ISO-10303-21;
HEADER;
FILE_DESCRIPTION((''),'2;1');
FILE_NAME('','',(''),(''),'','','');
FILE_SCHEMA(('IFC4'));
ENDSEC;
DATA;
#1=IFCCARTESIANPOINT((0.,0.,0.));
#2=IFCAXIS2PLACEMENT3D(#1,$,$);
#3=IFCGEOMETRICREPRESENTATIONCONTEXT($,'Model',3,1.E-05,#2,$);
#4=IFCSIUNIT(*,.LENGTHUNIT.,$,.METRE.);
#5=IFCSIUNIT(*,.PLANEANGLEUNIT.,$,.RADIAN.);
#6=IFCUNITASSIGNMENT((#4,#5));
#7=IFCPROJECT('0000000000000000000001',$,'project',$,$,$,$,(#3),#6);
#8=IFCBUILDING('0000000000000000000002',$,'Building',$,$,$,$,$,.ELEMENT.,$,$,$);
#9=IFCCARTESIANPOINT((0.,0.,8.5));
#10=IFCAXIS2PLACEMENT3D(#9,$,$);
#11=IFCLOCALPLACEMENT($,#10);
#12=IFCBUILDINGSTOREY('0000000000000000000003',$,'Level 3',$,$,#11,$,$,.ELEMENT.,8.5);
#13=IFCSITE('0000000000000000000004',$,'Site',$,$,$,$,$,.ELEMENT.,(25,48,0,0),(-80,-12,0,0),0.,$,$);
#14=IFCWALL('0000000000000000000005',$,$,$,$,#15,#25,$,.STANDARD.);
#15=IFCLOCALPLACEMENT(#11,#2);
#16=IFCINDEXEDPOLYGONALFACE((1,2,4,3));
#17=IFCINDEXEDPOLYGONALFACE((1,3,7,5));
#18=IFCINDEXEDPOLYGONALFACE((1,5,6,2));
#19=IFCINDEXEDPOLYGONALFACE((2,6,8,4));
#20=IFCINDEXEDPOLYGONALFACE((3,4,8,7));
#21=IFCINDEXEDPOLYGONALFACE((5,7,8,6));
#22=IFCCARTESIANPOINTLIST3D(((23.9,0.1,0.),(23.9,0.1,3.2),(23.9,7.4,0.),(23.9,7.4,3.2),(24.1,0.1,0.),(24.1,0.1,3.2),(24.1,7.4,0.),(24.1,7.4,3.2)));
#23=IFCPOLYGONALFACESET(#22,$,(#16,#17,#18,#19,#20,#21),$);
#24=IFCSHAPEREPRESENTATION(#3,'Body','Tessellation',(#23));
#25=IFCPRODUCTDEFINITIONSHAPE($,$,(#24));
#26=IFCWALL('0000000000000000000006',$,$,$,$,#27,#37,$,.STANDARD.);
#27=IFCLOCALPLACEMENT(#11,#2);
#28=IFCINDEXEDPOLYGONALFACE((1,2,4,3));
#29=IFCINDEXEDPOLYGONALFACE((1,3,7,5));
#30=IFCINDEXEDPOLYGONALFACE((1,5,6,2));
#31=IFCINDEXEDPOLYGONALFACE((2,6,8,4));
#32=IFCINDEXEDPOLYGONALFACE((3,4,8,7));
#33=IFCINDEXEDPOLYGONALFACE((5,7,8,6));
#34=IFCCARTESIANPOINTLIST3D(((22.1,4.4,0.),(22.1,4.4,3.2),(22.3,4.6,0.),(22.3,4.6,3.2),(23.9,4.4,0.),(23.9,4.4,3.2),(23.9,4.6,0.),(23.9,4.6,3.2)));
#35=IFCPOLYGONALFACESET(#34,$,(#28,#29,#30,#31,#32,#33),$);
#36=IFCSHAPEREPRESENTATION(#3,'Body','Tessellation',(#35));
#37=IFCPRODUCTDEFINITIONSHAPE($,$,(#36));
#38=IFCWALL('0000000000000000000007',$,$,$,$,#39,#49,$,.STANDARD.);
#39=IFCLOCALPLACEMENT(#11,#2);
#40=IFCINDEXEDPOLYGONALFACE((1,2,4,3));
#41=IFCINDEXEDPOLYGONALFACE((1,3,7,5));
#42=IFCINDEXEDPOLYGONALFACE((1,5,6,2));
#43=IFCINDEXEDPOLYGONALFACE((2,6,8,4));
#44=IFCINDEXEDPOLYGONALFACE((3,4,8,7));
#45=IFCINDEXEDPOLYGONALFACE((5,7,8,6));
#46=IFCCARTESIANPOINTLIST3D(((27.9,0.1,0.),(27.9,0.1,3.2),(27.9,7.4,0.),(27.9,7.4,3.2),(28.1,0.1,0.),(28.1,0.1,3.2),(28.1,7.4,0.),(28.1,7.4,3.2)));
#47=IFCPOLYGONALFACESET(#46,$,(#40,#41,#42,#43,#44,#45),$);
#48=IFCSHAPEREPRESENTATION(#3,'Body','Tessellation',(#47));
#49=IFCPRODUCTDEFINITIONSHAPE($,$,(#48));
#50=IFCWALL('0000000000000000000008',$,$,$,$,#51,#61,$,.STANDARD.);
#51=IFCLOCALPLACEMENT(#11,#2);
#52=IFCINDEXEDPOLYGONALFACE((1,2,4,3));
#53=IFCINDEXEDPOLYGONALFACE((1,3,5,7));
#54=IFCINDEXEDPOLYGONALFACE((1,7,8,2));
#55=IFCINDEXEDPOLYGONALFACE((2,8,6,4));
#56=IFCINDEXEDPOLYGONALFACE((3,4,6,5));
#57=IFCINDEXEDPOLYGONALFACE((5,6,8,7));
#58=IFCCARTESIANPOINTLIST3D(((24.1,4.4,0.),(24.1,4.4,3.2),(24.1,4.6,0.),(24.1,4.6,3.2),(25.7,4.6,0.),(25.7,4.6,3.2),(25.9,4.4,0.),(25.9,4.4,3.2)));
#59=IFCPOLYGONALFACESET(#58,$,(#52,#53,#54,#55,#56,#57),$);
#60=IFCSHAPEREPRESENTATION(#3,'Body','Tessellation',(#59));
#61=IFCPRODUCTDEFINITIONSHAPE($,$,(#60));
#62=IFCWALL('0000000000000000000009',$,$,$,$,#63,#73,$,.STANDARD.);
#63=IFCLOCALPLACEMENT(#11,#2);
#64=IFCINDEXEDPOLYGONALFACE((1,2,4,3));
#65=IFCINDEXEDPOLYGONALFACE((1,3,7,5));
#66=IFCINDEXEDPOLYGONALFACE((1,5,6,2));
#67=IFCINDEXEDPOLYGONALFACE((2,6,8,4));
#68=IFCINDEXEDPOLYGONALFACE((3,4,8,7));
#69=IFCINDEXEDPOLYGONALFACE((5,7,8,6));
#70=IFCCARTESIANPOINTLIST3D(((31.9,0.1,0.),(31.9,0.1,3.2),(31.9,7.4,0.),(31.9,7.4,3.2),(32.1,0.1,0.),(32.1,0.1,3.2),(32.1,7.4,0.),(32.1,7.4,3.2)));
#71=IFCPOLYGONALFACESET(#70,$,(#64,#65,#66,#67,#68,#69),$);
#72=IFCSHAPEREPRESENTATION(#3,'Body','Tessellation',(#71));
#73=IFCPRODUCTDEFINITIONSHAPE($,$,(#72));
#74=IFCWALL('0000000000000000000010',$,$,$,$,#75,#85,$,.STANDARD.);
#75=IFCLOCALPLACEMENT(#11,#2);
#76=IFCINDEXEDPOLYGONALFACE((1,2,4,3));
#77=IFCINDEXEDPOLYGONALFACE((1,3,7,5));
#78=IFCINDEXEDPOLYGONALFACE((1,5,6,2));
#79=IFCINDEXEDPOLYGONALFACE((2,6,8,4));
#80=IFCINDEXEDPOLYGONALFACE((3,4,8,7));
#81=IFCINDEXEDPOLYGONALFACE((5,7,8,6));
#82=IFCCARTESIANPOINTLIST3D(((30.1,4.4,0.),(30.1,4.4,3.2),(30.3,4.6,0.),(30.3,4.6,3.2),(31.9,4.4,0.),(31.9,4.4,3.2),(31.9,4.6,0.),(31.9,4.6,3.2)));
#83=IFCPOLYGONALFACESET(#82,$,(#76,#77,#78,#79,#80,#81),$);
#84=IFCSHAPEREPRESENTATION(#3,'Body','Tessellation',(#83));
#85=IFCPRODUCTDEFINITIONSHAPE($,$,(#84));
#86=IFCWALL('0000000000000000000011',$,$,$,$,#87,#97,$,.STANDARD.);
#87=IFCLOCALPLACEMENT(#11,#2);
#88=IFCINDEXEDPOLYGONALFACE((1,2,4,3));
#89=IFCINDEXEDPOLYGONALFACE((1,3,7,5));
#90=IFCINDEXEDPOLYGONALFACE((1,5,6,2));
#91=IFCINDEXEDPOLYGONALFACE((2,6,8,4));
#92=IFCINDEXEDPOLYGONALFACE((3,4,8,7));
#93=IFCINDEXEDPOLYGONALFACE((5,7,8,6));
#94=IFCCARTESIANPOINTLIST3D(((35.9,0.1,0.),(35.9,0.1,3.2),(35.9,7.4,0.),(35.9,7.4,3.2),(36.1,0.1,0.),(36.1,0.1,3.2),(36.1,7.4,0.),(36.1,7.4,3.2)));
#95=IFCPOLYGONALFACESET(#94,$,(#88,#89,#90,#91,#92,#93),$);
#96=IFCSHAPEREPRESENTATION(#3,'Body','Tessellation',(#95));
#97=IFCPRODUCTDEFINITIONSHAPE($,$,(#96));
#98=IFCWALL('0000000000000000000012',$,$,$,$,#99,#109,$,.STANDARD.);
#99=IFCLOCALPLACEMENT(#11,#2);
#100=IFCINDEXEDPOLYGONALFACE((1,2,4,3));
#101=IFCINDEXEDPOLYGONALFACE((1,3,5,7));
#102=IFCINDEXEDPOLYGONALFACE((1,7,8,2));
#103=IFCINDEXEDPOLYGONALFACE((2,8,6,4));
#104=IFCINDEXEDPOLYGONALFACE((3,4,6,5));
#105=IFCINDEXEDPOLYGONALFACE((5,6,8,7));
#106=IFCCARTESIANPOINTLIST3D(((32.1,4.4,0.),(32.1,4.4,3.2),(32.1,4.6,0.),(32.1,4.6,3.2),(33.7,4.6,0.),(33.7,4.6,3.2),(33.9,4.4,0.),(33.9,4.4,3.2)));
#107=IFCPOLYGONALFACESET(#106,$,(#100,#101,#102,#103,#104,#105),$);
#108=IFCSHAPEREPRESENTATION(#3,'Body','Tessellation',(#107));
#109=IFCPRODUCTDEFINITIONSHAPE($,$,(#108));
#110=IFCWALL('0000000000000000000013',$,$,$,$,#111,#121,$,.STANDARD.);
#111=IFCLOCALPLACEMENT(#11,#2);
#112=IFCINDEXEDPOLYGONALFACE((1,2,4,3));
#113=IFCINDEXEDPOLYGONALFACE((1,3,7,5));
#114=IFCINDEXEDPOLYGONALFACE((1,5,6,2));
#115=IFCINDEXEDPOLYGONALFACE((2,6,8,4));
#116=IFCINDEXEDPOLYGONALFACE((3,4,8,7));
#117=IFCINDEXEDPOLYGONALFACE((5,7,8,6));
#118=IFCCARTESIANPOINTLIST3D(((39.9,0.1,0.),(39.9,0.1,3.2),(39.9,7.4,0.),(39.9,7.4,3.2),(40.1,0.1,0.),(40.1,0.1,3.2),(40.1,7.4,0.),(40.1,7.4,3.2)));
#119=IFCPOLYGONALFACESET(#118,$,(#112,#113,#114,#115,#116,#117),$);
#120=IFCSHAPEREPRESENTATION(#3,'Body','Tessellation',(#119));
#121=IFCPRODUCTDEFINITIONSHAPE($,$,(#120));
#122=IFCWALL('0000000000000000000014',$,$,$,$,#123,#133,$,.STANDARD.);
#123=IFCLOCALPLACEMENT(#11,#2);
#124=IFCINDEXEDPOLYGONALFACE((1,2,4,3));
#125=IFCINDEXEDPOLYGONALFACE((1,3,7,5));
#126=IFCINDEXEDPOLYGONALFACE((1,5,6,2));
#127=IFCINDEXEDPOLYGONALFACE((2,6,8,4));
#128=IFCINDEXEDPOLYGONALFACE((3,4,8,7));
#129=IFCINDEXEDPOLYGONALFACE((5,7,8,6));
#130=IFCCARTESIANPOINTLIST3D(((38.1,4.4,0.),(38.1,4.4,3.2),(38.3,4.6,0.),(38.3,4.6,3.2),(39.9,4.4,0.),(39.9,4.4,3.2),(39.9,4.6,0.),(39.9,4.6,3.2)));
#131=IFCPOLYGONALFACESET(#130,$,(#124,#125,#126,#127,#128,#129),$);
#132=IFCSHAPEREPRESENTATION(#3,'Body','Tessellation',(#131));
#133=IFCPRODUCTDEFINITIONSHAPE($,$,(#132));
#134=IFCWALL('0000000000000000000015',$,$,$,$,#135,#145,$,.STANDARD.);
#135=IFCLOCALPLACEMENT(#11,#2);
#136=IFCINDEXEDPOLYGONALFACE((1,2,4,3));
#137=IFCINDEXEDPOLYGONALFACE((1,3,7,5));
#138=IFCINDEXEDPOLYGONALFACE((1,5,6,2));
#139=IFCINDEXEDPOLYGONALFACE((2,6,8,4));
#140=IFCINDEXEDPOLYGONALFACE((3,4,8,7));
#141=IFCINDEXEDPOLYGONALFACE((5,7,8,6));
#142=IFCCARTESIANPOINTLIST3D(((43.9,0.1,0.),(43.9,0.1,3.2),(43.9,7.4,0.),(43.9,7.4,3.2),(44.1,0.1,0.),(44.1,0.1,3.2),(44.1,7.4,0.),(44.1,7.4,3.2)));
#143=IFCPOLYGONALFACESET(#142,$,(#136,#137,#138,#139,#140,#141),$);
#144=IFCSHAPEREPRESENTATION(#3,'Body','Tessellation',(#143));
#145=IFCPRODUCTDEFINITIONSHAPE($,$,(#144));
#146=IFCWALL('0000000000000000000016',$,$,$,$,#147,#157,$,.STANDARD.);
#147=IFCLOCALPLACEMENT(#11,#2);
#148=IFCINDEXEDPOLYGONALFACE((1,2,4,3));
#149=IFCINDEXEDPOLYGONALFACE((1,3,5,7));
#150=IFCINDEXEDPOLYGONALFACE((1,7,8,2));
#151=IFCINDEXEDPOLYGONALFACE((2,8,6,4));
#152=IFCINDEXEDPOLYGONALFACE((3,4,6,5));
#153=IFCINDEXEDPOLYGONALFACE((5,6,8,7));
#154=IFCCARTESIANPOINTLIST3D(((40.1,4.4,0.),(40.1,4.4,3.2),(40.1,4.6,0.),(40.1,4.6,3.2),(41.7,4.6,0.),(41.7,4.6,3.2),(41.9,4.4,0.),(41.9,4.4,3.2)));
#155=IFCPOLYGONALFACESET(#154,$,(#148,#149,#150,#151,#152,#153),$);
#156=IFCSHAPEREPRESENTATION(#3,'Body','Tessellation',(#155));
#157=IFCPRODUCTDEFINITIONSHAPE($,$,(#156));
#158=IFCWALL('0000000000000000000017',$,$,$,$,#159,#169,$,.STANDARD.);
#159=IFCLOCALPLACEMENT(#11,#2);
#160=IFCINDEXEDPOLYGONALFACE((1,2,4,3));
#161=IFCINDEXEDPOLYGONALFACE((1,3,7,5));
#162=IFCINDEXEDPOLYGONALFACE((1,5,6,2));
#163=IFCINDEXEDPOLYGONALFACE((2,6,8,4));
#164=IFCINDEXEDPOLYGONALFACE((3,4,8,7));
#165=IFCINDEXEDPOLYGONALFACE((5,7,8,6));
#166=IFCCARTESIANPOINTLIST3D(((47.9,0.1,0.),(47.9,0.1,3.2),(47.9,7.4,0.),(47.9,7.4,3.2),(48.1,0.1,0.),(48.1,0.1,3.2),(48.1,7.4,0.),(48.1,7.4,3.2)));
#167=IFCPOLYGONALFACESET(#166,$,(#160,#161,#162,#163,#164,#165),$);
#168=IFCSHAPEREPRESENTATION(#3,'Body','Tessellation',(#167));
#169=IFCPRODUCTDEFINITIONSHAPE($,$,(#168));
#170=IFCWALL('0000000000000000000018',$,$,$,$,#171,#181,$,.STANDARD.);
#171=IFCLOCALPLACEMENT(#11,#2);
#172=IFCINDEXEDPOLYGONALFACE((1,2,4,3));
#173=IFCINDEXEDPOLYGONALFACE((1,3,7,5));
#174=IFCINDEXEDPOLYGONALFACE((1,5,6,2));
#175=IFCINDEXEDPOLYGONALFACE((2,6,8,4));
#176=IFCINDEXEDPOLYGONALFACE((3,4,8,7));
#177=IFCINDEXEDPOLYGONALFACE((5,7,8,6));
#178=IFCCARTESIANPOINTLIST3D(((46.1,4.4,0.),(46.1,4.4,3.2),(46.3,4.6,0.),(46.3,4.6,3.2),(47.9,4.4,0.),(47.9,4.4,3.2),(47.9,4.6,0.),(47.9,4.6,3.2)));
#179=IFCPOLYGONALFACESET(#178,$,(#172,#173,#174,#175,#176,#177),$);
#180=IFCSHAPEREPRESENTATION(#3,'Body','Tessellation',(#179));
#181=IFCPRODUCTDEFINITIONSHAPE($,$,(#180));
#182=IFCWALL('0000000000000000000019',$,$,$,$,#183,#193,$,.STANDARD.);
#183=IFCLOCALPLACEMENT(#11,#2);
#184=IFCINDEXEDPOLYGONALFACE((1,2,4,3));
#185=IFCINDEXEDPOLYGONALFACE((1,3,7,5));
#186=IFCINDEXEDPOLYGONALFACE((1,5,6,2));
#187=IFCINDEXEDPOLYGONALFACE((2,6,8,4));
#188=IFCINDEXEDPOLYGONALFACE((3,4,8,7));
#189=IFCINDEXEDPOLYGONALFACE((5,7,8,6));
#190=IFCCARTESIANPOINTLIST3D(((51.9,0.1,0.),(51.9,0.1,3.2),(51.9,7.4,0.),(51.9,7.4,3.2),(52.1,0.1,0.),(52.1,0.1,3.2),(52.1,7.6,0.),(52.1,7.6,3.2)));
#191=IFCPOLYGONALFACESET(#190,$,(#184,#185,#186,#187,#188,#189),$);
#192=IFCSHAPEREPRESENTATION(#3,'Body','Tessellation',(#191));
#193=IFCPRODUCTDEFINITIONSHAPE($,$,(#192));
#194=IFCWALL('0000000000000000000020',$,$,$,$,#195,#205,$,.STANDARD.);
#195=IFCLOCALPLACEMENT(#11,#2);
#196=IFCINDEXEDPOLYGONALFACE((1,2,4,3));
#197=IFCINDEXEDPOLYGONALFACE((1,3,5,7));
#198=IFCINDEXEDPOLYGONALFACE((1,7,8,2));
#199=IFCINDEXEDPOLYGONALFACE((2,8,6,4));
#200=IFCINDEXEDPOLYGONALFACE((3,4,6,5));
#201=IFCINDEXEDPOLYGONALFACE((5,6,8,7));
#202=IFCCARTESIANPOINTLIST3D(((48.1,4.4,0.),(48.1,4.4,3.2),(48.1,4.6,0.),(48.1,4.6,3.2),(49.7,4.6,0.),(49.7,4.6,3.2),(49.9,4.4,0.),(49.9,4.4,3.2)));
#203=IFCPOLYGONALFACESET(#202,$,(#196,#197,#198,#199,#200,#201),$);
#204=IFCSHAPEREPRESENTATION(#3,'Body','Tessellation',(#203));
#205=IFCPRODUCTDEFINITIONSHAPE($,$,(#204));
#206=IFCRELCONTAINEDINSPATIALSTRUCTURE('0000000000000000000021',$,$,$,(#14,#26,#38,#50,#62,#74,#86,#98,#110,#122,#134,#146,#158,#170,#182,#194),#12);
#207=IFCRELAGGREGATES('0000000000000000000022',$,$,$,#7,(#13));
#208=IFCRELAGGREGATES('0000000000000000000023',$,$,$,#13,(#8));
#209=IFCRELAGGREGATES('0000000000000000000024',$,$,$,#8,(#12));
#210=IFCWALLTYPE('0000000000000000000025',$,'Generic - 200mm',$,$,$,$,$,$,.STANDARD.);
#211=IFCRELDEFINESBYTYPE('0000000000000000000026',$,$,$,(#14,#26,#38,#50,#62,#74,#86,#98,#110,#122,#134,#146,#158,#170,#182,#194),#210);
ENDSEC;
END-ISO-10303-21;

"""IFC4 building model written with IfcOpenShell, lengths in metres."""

from ifc_helpers import new_model, si_unit, frame, origin, place, context, project, spatial, polyline, outline, extrude, type_object, element, save


model = new_model("IFC4")

# Units and contexts
model_context = context("Model", 3, precision=1e-05, world=origin())
ifc_project = project(units=[si_unit("LENGTHUNIT", "METRE"), si_unit("PLANEANGLEUNIT", "RADIAN")], contexts=[model_context])

# Site, building, storey
site = spatial("IfcSite", under=ifc_project, Name="Site", CompositionType="ELEMENT", RefLatitude=(25, 48, 0, 0), RefLongitude=(-80, -12, 0, 0), RefElevation=0.0)
building = spatial("IfcBuilding", under=site, Name="Building", CompositionType="ELEMENT")
storey_placement = place(None, frame((0.0, 0.0, 8.5)))
storey = spatial("IfcBuildingStorey", under=building, at=storey_placement, Name="Level 3", CompositionType="ELEMENT", Elevation=8.5)

# Shared definitions
wall_type = type_object("IfcWallType", Name="Generic - 200mm", PredefinedType="STANDARD")

# Walls
wall_1_placement = place(None, frame((24.0, 7.5, 8.5), z_axis=(0.0, 0.0, 1.0), x_axis=(0.0, -1.0, 0.0)))
element("IfcWall", 1, at=wall_1_placement, inside=storey, type_object=wall_type, PredefinedType="STANDARD", context=model_context, shape_type="SweptSolid", body=[
    extrude(outline(polyline([(0.1, -0.1), (7.4, -0.1), (7.4, 0.1), (0.1, 0.1), (0.1, -0.1)])), origin(), (0.0, 0.0, 1.0), 3.2),
])
wall_2_placement = place(None, frame((22.2, 4.5, 8.5), z_axis=(0.0, 0.0, 1.0), x_axis=(1.0, 0.0, 0.0)))
element("IfcWall", 2, at=wall_2_placement, inside=storey, type_object=wall_type, PredefinedType="STANDARD", context=model_context, shape_type="SweptSolid", body=[
    extrude(outline(polyline([(-0.1, -0.1), (1.7, -0.1), (1.7, 0.1), (0.1, 0.1), (-0.1, -0.1)])), origin(), (0.0, 0.0, 1.0), 3.2),
])
wall_3_placement = place(None, frame((28.0, 7.5, 8.5), z_axis=(0.0, 0.0, 1.0), x_axis=(0.0, -1.0, 0.0)))
element("IfcWall", 3, at=wall_3_placement, inside=storey, type_object=wall_type, PredefinedType="STANDARD", context=model_context, shape_type="SweptSolid", body=[
    extrude(outline(polyline([(0.1, -0.1), (7.4, -0.1), (7.4, 0.1), (0.1, 0.1), (0.1, -0.1)])), origin(), (0.0, 0.0, 1.0), 3.2),
])
wall_4_placement = place(None, frame((25.8, 4.5, 8.5), z_axis=(0.0, 0.0, 1.0), x_axis=(-1.0, 0.0, 0.0)))
element("IfcWall", 4, at=wall_4_placement, inside=storey, type_object=wall_type, PredefinedType="STANDARD", context=model_context, shape_type="SweptSolid", body=[
    extrude(outline(polyline([(0.1, -0.1), (1.7, -0.1), (1.7, 0.1), (-0.1, 0.1), (0.1, -0.1)])), origin(), (0.0, 0.0, 1.0), 3.2),
])
wall_5_placement = place(None, frame((32.0, 7.5, 8.5), z_axis=(0.0, 0.0, 1.0), x_axis=(0.0, -1.0, 0.0)))
element("IfcWall", 5, at=wall_5_placement, inside=storey, type_object=wall_type, PredefinedType="STANDARD", context=model_context, shape_type="SweptSolid", body=[
    extrude(outline(polyline([(0.1, -0.1), (7.4, -0.1), (7.4, 0.1), (0.1, 0.1), (0.1, -0.1)])), origin(), (0.0, 0.0, 1.0), 3.2),
])
wall_6_placement = place(None, frame((30.2, 4.5, 8.5), z_axis=(0.0, 0.0, 1.0), x_axis=(1.0, 0.0, 0.0)))
element("IfcWall", 6, at=wall_6_placement, inside=storey, type_object=wall_type, PredefinedType="STANDARD", context=model_context, shape_type="SweptSolid", body=[
    extrude(outline(polyline([(-0.1, -0.1), (1.7, -0.1), (1.7, 0.1), (0.1, 0.1), (-0.1, -0.1)])), origin(), (0.0, 0.0, 1.0), 3.2),
])
wall_7_placement = place(None, frame((36.0, 7.5, 8.5), z_axis=(0.0, 0.0, 1.0), x_axis=(0.0, -1.0, 0.0)))
element("IfcWall", 7, at=wall_7_placement, inside=storey, type_object=wall_type, PredefinedType="STANDARD", context=model_context, shape_type="SweptSolid", body=[
    extrude(outline(polyline([(0.1, -0.1), (7.4, -0.1), (7.4, 0.1), (0.1, 0.1), (0.1, -0.1)])), origin(), (0.0, 0.0, 1.0), 3.2),
])
wall_8_placement = place(None, frame((33.8, 4.5, 8.5), z_axis=(0.0, 0.0, 1.0), x_axis=(-1.0, 0.0, 0.0)))
element("IfcWall", 8, at=wall_8_placement, inside=storey, type_object=wall_type, PredefinedType="STANDARD", context=model_context, shape_type="SweptSolid", body=[
    extrude(outline(polyline([(0.1, -0.1), (1.7, -0.1), (1.7, 0.1), (-0.1, 0.1), (0.1, -0.1)])), origin(), (0.0, 0.0, 1.0), 3.2),
])
wall_9_placement = place(None, frame((40.0, 7.5, 8.5), z_axis=(0.0, 0.0, 1.0), x_axis=(0.0, -1.0, 0.0)))
element("IfcWall", 9, at=wall_9_placement, inside=storey, type_object=wall_type, PredefinedType="STANDARD", context=model_context, shape_type="SweptSolid", body=[
    extrude(outline(polyline([(0.1, -0.1), (7.4, -0.1), (7.4, 0.1), (0.1, 0.1), (0.1, -0.1)])), origin(), (0.0, 0.0, 1.0), 3.2),
])
wall_10_placement = place(None, frame((38.2, 4.5, 8.5), z_axis=(0.0, 0.0, 1.0), x_axis=(1.0, 0.0, 0.0)))
element("IfcWall", 10, at=wall_10_placement, inside=storey, type_object=wall_type, PredefinedType="STANDARD", context=model_context, shape_type="SweptSolid", body=[
    extrude(outline(polyline([(-0.1, -0.1), (1.7, -0.1), (1.7, 0.1), (0.1, 0.1), (-0.1, -0.1)])), origin(), (0.0, 0.0, 1.0), 3.2),
])
wall_11_placement = place(None, frame((44.0, 7.5, 8.5), z_axis=(0.0, 0.0, 1.0), x_axis=(0.0, -1.0, 0.0)))
element("IfcWall", 11, at=wall_11_placement, inside=storey, type_object=wall_type, PredefinedType="STANDARD", context=model_context, shape_type="SweptSolid", body=[
    extrude(outline(polyline([(0.1, -0.1), (7.4, -0.1), (7.4, 0.1), (0.1, 0.1), (0.1, -0.1)])), origin(), (0.0, 0.0, 1.0), 3.2),
])
wall_12_placement = place(None, frame((41.8, 4.5, 8.5), z_axis=(0.0, 0.0, 1.0), x_axis=(-1.0, 0.0, 0.0)))
element("IfcWall", 12, at=wall_12_placement, inside=storey, type_object=wall_type, PredefinedType="STANDARD", context=model_context, shape_type="SweptSolid", body=[
    extrude(outline(polyline([(0.1, -0.1), (1.7, -0.1), (1.7, 0.1), (-0.1, 0.1), (0.1, -0.1)])), origin(), (0.0, 0.0, 1.0), 3.2),
])
wall_13_placement = place(None, frame((48.0, 7.5, 8.5), z_axis=(0.0, 0.0, 1.0), x_axis=(0.0, -1.0, 0.0)))
element("IfcWall", 13, at=wall_13_placement, inside=storey, type_object=wall_type, PredefinedType="STANDARD", context=model_context, shape_type="SweptSolid", body=[
    extrude(outline(polyline([(0.1, -0.1), (7.4, -0.1), (7.4, 0.1), (0.1, 0.1), (0.1, -0.1)])), origin(), (0.0, 0.0, 1.0), 3.2),
])
wall_14_placement = place(None, frame((46.2, 4.5, 8.5), z_axis=(0.0, 0.0, 1.0), x_axis=(1.0, 0.0, 0.0)))
element("IfcWall", 14, at=wall_14_placement, inside=storey, type_object=wall_type, PredefinedType="STANDARD", context=model_context, shape_type="SweptSolid", body=[
    extrude(outline(polyline([(-0.1, -0.1), (1.7, -0.1), (1.7, 0.1), (0.1, 0.1), (-0.1, -0.1)])), origin(), (0.0, 0.0, 1.0), 3.2),
])
wall_15_placement = place(None, frame((52.0, 7.5, 8.5), z_axis=(0.0, 0.0, 1.0), x_axis=(0.0, -1.0, 0.0)))
element("IfcWall", 15, at=wall_15_placement, inside=storey, type_object=wall_type, PredefinedType="STANDARD", context=model_context, shape_type="SweptSolid", body=[
    extrude(outline(polyline([(0.1, -0.1), (7.4, -0.1), (7.4, 0.1), (-0.1, 0.1), (0.1, -0.1)])), origin(), (0.0, 0.0, 1.0), 3.2),
])
wall_16_placement = place(None, frame((49.8, 4.5, 8.5), z_axis=(0.0, 0.0, 1.0), x_axis=(-1.0, 0.0, 0.0)))
element("IfcWall", 16, at=wall_16_placement, inside=storey, type_object=wall_type, PredefinedType="STANDARD", context=model_context, shape_type="SweptSolid", body=[
    extrude(outline(polyline([(0.1, -0.1), (1.7, -0.1), (1.7, 0.1), (-0.1, 0.1), (0.1, -0.1)])), origin(), (0.0, 0.0, 1.0), 3.2),
])

save(model, "model.ifc")
